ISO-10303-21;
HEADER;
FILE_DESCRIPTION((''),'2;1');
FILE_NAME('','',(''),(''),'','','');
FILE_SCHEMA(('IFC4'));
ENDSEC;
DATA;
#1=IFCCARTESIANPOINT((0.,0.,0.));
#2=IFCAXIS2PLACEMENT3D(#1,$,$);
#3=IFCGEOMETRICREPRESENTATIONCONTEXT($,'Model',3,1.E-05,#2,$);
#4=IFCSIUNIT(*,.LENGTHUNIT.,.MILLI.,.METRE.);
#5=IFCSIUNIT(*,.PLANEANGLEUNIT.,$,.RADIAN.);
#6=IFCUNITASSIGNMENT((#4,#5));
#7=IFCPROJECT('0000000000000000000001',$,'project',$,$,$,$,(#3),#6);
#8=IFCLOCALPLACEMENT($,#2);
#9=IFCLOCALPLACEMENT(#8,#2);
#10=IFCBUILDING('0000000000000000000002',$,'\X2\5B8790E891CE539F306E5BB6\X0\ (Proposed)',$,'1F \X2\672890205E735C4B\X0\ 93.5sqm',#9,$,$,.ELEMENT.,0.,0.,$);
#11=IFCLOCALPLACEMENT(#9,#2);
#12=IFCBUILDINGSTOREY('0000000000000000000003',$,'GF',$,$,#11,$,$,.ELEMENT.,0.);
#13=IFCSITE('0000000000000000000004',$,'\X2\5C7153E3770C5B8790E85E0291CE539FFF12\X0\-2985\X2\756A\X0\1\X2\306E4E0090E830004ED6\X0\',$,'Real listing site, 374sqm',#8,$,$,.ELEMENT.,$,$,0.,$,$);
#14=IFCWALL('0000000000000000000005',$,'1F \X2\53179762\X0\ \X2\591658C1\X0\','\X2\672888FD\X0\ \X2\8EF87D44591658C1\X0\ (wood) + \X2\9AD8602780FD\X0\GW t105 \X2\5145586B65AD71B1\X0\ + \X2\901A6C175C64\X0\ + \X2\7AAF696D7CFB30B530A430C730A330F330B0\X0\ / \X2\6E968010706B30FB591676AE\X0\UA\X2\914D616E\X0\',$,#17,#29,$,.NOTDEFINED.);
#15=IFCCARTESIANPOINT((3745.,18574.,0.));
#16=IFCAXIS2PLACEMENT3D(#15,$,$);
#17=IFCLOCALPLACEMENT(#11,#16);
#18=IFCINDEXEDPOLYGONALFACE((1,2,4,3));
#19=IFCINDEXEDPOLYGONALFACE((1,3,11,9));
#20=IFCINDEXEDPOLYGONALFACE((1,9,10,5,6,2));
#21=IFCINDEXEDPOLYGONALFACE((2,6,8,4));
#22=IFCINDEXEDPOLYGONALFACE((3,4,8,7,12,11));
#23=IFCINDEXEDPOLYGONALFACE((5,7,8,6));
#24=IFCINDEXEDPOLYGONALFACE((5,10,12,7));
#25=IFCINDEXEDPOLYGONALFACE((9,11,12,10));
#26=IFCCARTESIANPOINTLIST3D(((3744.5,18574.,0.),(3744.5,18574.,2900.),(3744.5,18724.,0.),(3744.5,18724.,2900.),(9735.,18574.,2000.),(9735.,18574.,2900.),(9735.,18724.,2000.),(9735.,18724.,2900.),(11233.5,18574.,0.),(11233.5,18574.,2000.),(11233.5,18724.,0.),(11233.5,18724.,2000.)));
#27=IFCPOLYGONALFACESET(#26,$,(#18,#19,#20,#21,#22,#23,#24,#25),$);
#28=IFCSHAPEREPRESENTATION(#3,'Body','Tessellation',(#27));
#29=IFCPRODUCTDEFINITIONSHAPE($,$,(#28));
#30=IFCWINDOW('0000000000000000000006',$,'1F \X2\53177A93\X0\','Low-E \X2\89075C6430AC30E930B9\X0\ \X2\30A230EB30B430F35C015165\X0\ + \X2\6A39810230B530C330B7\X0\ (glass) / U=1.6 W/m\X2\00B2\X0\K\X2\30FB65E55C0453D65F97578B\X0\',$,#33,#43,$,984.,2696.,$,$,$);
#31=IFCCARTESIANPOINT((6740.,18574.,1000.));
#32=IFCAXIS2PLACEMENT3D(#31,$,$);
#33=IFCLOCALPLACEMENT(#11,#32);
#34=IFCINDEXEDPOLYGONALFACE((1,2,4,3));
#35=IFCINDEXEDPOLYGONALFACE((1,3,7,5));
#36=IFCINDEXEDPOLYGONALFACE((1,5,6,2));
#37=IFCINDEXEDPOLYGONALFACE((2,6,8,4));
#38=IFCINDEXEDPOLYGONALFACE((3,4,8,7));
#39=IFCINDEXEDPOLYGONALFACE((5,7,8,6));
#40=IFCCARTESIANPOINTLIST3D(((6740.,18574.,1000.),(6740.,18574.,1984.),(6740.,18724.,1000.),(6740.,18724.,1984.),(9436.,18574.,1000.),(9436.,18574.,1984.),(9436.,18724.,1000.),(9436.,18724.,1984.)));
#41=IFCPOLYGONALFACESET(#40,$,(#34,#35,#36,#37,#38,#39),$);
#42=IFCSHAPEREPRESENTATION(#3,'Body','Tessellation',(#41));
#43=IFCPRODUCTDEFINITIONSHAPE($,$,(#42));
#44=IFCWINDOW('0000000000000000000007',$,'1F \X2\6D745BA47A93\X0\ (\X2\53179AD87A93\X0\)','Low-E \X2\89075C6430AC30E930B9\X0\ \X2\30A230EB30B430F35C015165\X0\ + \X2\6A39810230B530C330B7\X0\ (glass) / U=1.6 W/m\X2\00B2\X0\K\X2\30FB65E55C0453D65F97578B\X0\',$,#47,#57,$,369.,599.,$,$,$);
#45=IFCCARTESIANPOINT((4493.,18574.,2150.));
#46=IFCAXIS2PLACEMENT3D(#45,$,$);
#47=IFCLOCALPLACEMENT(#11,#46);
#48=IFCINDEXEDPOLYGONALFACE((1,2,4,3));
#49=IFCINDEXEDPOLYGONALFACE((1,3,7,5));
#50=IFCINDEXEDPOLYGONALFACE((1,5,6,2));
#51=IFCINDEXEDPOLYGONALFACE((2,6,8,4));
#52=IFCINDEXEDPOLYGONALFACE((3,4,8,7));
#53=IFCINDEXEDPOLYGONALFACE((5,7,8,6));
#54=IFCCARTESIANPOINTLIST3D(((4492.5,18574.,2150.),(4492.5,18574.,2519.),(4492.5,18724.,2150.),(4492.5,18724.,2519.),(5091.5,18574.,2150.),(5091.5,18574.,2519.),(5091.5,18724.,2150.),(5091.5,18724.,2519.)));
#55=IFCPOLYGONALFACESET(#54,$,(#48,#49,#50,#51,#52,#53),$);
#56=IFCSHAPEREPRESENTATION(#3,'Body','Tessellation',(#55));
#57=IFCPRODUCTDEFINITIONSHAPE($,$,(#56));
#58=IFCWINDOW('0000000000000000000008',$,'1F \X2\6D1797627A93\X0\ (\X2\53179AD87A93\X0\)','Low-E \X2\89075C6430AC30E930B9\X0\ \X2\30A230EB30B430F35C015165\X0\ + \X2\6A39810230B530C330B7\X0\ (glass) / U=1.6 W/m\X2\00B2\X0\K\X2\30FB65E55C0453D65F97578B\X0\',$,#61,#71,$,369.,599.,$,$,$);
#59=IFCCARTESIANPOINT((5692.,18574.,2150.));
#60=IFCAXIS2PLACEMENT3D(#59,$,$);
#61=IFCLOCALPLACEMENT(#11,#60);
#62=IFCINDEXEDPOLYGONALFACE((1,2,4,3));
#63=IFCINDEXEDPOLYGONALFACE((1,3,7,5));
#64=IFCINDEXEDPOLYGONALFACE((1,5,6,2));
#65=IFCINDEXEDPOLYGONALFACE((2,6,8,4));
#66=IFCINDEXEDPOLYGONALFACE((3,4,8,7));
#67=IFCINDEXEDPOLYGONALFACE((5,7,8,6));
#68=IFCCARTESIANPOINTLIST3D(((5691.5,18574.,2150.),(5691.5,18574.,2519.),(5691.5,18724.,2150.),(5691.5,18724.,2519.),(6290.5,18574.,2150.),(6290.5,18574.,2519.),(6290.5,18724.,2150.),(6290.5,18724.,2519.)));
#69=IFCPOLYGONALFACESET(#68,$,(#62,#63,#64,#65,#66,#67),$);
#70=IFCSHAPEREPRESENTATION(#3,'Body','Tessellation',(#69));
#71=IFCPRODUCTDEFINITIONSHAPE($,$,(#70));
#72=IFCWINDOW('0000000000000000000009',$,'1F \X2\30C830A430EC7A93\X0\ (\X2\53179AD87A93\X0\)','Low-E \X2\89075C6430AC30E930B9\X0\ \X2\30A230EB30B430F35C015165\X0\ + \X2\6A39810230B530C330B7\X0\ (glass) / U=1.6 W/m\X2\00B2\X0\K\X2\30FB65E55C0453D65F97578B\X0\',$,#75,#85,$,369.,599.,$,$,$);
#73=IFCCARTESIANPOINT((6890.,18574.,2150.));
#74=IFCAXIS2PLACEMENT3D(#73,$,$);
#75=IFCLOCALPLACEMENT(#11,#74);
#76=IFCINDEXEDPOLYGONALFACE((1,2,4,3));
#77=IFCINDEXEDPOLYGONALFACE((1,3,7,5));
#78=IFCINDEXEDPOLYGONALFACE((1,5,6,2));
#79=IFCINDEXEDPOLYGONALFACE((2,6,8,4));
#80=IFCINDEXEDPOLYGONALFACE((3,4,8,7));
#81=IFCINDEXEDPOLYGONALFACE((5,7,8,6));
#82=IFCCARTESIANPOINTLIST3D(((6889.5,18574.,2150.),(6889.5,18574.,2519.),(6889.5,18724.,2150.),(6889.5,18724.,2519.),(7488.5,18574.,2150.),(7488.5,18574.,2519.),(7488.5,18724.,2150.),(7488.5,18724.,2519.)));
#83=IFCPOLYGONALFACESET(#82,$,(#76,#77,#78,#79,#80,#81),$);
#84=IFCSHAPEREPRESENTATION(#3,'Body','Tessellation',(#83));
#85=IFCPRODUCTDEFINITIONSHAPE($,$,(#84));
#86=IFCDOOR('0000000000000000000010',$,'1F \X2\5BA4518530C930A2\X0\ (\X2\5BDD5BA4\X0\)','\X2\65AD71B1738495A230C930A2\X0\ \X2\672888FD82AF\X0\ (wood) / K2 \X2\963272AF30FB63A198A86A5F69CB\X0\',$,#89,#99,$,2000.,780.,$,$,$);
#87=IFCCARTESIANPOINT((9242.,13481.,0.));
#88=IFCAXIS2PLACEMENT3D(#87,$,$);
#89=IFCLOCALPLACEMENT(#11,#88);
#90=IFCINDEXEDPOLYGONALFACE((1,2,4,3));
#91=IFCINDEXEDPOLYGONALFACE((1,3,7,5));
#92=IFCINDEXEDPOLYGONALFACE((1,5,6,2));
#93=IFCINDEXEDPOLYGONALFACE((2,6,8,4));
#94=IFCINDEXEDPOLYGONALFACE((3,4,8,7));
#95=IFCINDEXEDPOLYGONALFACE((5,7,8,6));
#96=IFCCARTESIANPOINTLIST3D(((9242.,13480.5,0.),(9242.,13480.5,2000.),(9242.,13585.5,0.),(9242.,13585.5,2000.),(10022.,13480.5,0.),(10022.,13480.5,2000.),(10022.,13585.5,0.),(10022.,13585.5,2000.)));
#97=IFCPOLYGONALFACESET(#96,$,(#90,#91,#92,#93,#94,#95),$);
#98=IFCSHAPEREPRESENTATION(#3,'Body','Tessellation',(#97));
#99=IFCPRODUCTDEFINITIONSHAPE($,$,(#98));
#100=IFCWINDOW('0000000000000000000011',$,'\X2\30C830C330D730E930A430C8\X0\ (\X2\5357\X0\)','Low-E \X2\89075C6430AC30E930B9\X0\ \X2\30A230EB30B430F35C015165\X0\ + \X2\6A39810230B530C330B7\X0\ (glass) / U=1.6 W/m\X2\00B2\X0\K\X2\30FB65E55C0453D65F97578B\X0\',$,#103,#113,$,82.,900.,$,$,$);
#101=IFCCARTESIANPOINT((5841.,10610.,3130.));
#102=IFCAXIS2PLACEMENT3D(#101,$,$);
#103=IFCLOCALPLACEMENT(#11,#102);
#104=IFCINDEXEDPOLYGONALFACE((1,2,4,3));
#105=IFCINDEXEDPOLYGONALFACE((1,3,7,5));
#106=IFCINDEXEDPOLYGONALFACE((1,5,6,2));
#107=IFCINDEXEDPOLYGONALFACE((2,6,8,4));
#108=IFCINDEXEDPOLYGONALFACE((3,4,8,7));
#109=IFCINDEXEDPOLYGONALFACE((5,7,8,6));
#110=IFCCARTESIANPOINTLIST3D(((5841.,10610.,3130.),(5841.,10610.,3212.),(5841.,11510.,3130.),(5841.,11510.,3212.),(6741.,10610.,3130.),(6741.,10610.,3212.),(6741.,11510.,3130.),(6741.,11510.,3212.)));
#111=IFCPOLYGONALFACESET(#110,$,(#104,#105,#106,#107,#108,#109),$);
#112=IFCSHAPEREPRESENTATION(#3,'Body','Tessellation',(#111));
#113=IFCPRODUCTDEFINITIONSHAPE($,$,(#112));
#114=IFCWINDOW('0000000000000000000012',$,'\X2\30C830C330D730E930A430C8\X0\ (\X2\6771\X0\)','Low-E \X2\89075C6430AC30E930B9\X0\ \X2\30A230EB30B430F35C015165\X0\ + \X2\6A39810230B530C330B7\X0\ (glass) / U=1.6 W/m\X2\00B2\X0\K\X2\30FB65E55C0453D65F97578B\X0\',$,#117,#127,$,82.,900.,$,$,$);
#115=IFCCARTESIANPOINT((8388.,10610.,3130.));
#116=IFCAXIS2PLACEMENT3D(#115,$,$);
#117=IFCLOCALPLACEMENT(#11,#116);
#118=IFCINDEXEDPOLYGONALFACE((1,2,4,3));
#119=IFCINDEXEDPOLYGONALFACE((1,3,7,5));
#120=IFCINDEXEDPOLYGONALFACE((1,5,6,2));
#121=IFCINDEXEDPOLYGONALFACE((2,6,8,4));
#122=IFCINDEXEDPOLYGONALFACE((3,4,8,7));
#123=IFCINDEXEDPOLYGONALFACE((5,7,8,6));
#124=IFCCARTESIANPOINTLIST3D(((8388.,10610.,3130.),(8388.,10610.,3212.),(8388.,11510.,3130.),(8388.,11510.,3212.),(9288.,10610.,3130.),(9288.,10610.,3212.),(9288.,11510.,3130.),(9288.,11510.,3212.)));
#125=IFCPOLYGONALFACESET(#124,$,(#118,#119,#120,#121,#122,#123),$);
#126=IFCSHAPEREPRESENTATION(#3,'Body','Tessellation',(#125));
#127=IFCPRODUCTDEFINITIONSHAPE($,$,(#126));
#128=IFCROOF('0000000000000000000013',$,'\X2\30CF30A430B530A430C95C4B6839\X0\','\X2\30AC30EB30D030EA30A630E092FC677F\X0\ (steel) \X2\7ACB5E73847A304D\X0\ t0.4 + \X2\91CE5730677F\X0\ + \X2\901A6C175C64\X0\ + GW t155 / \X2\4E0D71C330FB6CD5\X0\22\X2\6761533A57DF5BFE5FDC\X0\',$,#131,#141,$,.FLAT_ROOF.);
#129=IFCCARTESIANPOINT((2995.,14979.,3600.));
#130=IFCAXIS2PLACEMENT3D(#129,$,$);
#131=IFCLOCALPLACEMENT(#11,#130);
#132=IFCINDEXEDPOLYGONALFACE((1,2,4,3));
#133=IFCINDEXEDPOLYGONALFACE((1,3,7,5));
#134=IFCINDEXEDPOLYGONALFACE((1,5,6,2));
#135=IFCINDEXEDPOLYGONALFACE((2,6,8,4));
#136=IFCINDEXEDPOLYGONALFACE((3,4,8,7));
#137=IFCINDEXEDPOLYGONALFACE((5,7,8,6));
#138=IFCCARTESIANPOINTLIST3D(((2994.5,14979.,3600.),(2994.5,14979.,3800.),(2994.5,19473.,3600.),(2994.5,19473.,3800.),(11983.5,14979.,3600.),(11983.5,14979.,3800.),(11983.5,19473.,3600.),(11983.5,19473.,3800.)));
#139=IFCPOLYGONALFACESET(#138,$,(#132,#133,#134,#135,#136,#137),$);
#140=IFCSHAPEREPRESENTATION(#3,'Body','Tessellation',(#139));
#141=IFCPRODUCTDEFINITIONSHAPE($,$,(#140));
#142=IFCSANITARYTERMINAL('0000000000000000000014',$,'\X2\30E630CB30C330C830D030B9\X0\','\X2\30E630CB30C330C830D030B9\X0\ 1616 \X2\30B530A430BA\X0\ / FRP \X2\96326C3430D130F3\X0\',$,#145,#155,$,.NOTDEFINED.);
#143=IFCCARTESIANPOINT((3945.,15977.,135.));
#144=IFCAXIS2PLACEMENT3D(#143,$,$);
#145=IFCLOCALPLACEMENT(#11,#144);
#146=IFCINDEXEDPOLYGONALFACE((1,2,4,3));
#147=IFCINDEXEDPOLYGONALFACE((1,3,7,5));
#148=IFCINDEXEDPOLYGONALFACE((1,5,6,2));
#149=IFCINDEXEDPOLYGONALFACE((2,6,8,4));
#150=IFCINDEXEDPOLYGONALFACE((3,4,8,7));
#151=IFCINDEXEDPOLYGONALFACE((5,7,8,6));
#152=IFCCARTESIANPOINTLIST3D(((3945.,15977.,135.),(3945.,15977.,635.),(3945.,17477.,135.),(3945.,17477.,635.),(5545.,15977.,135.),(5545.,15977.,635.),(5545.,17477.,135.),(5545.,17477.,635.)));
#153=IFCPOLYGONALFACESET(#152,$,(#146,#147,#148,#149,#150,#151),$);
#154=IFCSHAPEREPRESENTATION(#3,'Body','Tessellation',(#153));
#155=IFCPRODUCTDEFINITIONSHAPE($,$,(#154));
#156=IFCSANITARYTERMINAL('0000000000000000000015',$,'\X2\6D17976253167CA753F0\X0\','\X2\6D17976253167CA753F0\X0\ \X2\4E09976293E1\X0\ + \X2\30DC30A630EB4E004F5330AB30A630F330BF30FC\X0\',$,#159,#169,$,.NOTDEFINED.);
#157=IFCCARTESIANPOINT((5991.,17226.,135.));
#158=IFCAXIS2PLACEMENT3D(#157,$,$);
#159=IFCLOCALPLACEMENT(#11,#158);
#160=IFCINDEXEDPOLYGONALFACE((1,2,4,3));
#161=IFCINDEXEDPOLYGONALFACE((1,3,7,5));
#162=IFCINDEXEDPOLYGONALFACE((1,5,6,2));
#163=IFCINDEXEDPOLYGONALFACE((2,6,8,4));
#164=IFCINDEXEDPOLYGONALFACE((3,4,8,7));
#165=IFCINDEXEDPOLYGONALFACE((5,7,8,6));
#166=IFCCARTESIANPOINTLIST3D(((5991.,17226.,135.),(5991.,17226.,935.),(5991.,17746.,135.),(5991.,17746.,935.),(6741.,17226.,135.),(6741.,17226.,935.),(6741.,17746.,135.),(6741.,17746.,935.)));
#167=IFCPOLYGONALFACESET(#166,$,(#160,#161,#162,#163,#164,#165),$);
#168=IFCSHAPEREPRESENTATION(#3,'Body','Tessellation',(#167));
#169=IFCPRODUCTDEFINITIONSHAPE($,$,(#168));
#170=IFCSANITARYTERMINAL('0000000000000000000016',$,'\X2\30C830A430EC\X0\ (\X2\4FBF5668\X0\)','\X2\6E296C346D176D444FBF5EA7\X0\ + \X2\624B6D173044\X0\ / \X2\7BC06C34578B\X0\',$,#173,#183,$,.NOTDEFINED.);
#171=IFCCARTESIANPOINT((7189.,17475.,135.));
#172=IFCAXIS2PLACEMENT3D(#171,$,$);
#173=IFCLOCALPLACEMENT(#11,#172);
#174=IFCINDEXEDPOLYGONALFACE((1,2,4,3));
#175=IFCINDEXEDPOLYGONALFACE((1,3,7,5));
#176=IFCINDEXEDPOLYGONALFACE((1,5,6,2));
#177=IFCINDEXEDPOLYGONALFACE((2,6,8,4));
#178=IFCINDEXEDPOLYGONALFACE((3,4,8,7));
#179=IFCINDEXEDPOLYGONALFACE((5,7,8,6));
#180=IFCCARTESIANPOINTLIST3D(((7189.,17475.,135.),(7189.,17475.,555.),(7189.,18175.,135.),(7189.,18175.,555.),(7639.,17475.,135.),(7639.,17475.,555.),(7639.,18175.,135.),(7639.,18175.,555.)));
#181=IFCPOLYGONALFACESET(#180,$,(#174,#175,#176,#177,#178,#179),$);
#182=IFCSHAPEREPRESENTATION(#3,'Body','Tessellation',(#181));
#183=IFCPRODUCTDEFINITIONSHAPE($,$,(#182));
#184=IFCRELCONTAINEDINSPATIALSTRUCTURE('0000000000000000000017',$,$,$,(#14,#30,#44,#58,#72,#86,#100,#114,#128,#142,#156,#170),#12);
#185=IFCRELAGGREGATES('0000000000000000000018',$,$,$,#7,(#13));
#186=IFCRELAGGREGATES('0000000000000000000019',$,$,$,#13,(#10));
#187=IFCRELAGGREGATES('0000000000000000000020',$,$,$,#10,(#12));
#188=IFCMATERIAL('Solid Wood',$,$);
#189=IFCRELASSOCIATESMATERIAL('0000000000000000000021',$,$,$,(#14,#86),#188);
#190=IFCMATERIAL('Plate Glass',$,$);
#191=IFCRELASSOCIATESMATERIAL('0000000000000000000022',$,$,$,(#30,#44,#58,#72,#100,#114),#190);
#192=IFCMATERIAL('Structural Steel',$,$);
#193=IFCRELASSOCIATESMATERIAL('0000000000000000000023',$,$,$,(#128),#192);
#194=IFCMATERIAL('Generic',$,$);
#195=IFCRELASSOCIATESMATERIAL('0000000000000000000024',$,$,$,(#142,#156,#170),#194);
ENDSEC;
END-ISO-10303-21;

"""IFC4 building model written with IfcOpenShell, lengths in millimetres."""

from ifc_helpers import new_model, si_unit, frame, frame_2d, origin, place, context, project, spatial, rectangle, extrude, material, element, fill, save


model = new_model("IFC4")

# Units and contexts
model_context = context("Model", 3, precision=1e-05, world=origin())
ifc_project = project(units=[si_unit("LENGTHUNIT", "METRE", prefix="MILLI"), si_unit("PLANEANGLEUNIT", "RADIAN")], contexts=[model_context])

# Site, building, storey
site_placement = place(None, origin())
site = spatial("IfcSite", under=ifc_project, at=site_placement, Name="山口県宇部市野原２-2985番1の一部　他", ObjectType="Real listing site, 374sqm", CompositionType="ELEMENT", RefElevation=0.0)
building_placement = place(site_placement, origin())
building = spatial("IfcBuilding", under=site, at=building_placement, Name="宇部野原の家 (Proposed)", ObjectType="1F 木造平屋 93.5sqm", CompositionType="ELEMENT", ElevationOfRefHeight=0.0, ElevationOfTerrain=0.0)
storey_placement = place(building_placement, origin())
storey = spatial("IfcBuildingStorey", under=building, at=storey_placement, Name="GF", CompositionType="ELEMENT", Elevation=0.0)

# Shared definitions
ifc_material_1 = material(Name="Solid Wood")

# Wall, openings, windows
wall_1_placement = place(storey_placement, frame((3745.0, 18574.0, 0.0)))
wall_1 = element("IfcWall", 1, at=wall_1_placement, inside=storey, material=ifc_material_1, Name="1F 北面 外壁", Description="木製 軸組外壁 (wood) + 高性能GW t105 充填断熱 + 通気層 + 窯業系サイディング / 準耐火・外皮UA配慮", PredefinedType="NOTDEFINED", context=model_context, shape_type="SweptSolid", body=[
    extrude(rectangle(XDim=7489.0, YDim=150.0, at=frame_2d((3744.0, 75.0))), frame((3745.0, 18574.0, 0.0)), (0.0, 0.0, 1.0), 2900.0),
])
opening_1_placement = place(storey_placement, frame((6740.0, 18574.0, 1000.0)))
opening_1 = element("IfcOpeningElement", 2, at=opening_1_placement, cuts=wall_1, PredefinedType="NOTDEFINED", context=model_context, shape_type="SweptSolid", body=[
    extrude(rectangle(XDim=2696.0, YDim=150.0, at=frame_2d((1348.0, 75.0))), frame((6740.0, 18574.0, 1000.0)), (0.0, 0.0, 1.0), 984.0),
])
opening_2_placement = place(storey_placement, frame((4493.0, 18574.0, 2150.0)))
opening_2 = element("IfcOpeningElement", 3, at=opening_2_placement, cuts=wall_1, PredefinedType="NOTDEFINED", context=model_context, shape_type="SweptSolid", body=[
    extrude(rectangle(XDim=599.0, YDim=150.0, at=frame_2d((299.0, 75.0))), frame((4493.0, 18574.0, 2150.0)), (0.0, 0.0, 1.0), 369.0),
])
opening_3_placement = place(storey_placement, frame((5692.0, 18574.0, 2150.0)))
opening_3 = element("IfcOpeningElement", 4, at=opening_3_placement, cuts=wall_1, PredefinedType="NOTDEFINED", context=model_context, shape_type="SweptSolid", body=[
    extrude(rectangle(XDim=599.0, YDim=150.0, at=frame_2d((299.0, 75.0))), frame((5692.0, 18574.0, 2150.0)), (0.0, 0.0, 1.0), 369.0),
])
opening_4_placement = place(storey_placement, frame((6890.0, 18574.0, 2150.0)))
opening_4 = element("IfcOpeningElement", 5, at=opening_4_placement, cuts=wall_1, PredefinedType="NOTDEFINED", context=model_context, shape_type="SweptSolid", body=[
    extrude(rectangle(XDim=599.0, YDim=150.0, at=frame_2d((299.0, 75.0))), frame((6890.0, 18574.0, 2150.0)), (0.0, 0.0, 1.0), 369.0),
])
ifc_material_2 = material(Name="Plate Glass")
window_1_placement = place(storey_placement, frame((6740.0, 18574.0, 1000.0)))
window_1 = element("IfcWindow", 6, at=window_1_placement, inside=storey, material=ifc_material_2, Name="1F 北窓", Description="Low-E 複層ガラス アルゴン封入 + 樹脂サッシ (glass) / U=1.6 W/m²K・日射取得型", OverallHeight=984.0, OverallWidth=2696.0, context=model_context, shape_type="SweptSolid", body=[
    extrude(rectangle(XDim=2696.0, YDim=150.0, at=frame_2d((1348.0, 75.0))), frame((6740.0, 18574.0, 1000.0)), (0.0, 0.0, 1.0), 984.0),
])
fill(opening_1, window_1)
window_2_placement = place(storey_placement, frame((4493.0, 18574.0, 2150.0)))
window_2 = element("IfcWindow", 7, at=window_2_placement, inside=storey, material=ifc_material_2, Name="1F 浴室窓 (北高窓)", Description="Low-E 複層ガラス アルゴン封入 + 樹脂サッシ (glass) / U=1.6 W/m²K・日射取得型", OverallHeight=369.0, OverallWidth=599.0, context=model_context, shape_type="SweptSolid", body=[
    extrude(rectangle(XDim=599.0, YDim=150.0, at=frame_2d((299.0, 75.0))), frame((4493.0, 18574.0, 2150.0)), (0.0, 0.0, 1.0), 369.0),
])
fill(opening_2, window_2)
window_3_placement = place(storey_placement, frame((5692.0, 18574.0, 2150.0)))
window_3 = element("IfcWindow", 8, at=window_3_placement, inside=storey, material=ifc_material_2, Name="1F 洗面窓 (北高窓)", Description="Low-E 複層ガラス アルゴン封入 + 樹脂サッシ (glass) / U=1.6 W/m²K・日射取得型", OverallHeight=369.0, OverallWidth=599.0, context=model_context, shape_type="SweptSolid", body=[
    extrude(rectangle(XDim=599.0, YDim=150.0, at=frame_2d((299.0, 75.0))), frame((5692.0, 18574.0, 2150.0)), (0.0, 0.0, 1.0), 369.0),
])
fill(opening_3, window_3)
window_4_placement = place(storey_placement, frame((6890.0, 18574.0, 2150.0)))
window_4 = element("IfcWindow", 9, at=window_4_placement, inside=storey, material=ifc_material_2, Name="1F トイレ窓 (北高窓)", Description="Low-E 複層ガラス アルゴン封入 + 樹脂サッシ (glass) / U=1.6 W/m²K・日射取得型", OverallHeight=369.0, OverallWidth=599.0, context=model_context, shape_type="SweptSolid", body=[
    extrude(rectangle(XDim=599.0, YDim=150.0, at=frame_2d((299.0, 75.0))), frame((6890.0, 18574.0, 2150.0)), (0.0, 0.0, 1.0), 369.0),
])
fill(opening_4, window_4)

# Door
door_1_placement = place(storey_placement, frame((9242.0, 13481.0, 0.0)))
element("IfcDoor", 10, at=door_1_placement, inside=storey, material=ifc_material_1, Name="1F 室内ドア (寝室)", Description="断熱玄関ドア 木製芯 (wood) / K2 防犯・採風機構", OverallHeight=2000.0, OverallWidth=780.0, context=model_context, shape_type="SweptSolid", body=[
    extrude(rectangle(XDim=780.0, YDim=105.0, at=frame_2d((390.0, 52.0))), frame((9242.0, 13481.0, 0.0)), (0.0, 0.0, 1.0), 2000.0),
])

# Windows
window_5_placement = place(storey_placement, frame((5841.0, 10610.0, 3130.0)))
element("IfcWindow", 11, at=window_5_placement, inside=storey, material=ifc_material_2, Name="トップライト (南)", Description="Low-E 複層ガラス アルゴン封入 + 樹脂サッシ (glass) / U=1.6 W/m²K・日射取得型", OverallHeight=82.0, OverallWidth=900.0, context=model_context, shape_type="SweptSolid", body=[
    extrude(rectangle(XDim=900.0, YDim=900.0, at=frame_2d((450.0, 450.0))), frame((5841.0, 10610.0, 3130.0)), (0.0, 0.0, 1.0), 82.0),
])
window_6_placement = place(storey_placement, frame((8388.0, 10610.0, 3130.0)))
element("IfcWindow", 12, at=window_6_placement, inside=storey, material=ifc_material_2, Name="トップライト (東)", Description="Low-E 複層ガラス アルゴン封入 + 樹脂サッシ (glass) / U=1.6 W/m²K・日射取得型", OverallHeight=82.0, OverallWidth=900.0, context=model_context, shape_type="SweptSolid", body=[
    extrude(rectangle(XDim=900.0, YDim=900.0, at=frame_2d((450.0, 450.0))), frame((8388.0, 10610.0, 3130.0)), (0.0, 0.0, 1.0), 82.0),
])

# Roof
ifc_material_3 = material(Name="Structural Steel")
roof_placement = place(storey_placement, frame((2995.0, 14979.0, 3600.0)))
element("IfcRoof", 13, at=roof_placement, inside=storey, material=ifc_material_3, Name="ハイサイド屋根", Description="ガルバリウム鋼板 (steel) 立平葺き t0.4 + 野地板 + 通気層 + GW t155 / 不燃・法22条区域対応", PredefinedType="FLAT_ROOF", context=model_context, shape_type="SweptSolid", body=[
    extrude(rectangle(XDim=8989.0, YDim=4494.0, at=frame_2d((4494.0, 2247.0))), frame((2995.0, 14979.0, 3600.0)), (0.0, 0.0, 1.0), 200.0),
])

# Sanitary terminals
ifc_material_4 = material(Name="Generic")
sanitary_terminal_1_placement = place(storey_placement, frame((3945.0, 15977.0, 135.0)))
element("IfcSanitaryTerminal", 14, at=sanitary_terminal_1_placement, inside=storey, material=ifc_material_4, Name="ユニットバス", Description="ユニットバス 1616 サイズ / FRP 防水パン", PredefinedType="NOTDEFINED", context=model_context, shape_type="SweptSolid", body=[
    extrude(rectangle(XDim=1600.0, YDim=1500.0, at=frame_2d((800.0, 750.0))), frame((3945.0, 15977.0, 135.0)), (0.0, 0.0, 1.0), 500.0),
])
sanitary_terminal_2_placement = place(storey_placement, frame((5991.0, 17226.0, 135.0)))
element("IfcSanitaryTerminal", 15, at=sanitary_terminal_2_placement, inside=storey, material=ifc_material_4, Name="洗面化粧台", Description="洗面化粧台 三面鏡 + ボウル一体カウンター", PredefinedType="NOTDEFINED", context=model_context, shape_type="SweptSolid", body=[
    extrude(rectangle(XDim=750.0, YDim=520.0, at=frame_2d((375.0, 260.0))), frame((5991.0, 17226.0, 135.0)), (0.0, 0.0, 1.0), 800.0),
])
sanitary_terminal_3_placement = place(storey_placement, frame((7189.0, 17475.0, 135.0)))
element("IfcSanitaryTerminal", 16, at=sanitary_terminal_3_placement, inside=storey, material=ifc_material_4, Name="トイレ (便器)", Description="温水洗浄便座 + 手洗い / 節水型", PredefinedType="NOTDEFINED", context=model_context, shape_type="SweptSolid", body=[
    extrude(rectangle(XDim=450.0, YDim=700.0, at=frame_2d((225.0, 350.0))), frame((7189.0, 17475.0, 135.0)), (0.0, 0.0, 1.0), 420.0),
])

save(model, "model.ifc")
